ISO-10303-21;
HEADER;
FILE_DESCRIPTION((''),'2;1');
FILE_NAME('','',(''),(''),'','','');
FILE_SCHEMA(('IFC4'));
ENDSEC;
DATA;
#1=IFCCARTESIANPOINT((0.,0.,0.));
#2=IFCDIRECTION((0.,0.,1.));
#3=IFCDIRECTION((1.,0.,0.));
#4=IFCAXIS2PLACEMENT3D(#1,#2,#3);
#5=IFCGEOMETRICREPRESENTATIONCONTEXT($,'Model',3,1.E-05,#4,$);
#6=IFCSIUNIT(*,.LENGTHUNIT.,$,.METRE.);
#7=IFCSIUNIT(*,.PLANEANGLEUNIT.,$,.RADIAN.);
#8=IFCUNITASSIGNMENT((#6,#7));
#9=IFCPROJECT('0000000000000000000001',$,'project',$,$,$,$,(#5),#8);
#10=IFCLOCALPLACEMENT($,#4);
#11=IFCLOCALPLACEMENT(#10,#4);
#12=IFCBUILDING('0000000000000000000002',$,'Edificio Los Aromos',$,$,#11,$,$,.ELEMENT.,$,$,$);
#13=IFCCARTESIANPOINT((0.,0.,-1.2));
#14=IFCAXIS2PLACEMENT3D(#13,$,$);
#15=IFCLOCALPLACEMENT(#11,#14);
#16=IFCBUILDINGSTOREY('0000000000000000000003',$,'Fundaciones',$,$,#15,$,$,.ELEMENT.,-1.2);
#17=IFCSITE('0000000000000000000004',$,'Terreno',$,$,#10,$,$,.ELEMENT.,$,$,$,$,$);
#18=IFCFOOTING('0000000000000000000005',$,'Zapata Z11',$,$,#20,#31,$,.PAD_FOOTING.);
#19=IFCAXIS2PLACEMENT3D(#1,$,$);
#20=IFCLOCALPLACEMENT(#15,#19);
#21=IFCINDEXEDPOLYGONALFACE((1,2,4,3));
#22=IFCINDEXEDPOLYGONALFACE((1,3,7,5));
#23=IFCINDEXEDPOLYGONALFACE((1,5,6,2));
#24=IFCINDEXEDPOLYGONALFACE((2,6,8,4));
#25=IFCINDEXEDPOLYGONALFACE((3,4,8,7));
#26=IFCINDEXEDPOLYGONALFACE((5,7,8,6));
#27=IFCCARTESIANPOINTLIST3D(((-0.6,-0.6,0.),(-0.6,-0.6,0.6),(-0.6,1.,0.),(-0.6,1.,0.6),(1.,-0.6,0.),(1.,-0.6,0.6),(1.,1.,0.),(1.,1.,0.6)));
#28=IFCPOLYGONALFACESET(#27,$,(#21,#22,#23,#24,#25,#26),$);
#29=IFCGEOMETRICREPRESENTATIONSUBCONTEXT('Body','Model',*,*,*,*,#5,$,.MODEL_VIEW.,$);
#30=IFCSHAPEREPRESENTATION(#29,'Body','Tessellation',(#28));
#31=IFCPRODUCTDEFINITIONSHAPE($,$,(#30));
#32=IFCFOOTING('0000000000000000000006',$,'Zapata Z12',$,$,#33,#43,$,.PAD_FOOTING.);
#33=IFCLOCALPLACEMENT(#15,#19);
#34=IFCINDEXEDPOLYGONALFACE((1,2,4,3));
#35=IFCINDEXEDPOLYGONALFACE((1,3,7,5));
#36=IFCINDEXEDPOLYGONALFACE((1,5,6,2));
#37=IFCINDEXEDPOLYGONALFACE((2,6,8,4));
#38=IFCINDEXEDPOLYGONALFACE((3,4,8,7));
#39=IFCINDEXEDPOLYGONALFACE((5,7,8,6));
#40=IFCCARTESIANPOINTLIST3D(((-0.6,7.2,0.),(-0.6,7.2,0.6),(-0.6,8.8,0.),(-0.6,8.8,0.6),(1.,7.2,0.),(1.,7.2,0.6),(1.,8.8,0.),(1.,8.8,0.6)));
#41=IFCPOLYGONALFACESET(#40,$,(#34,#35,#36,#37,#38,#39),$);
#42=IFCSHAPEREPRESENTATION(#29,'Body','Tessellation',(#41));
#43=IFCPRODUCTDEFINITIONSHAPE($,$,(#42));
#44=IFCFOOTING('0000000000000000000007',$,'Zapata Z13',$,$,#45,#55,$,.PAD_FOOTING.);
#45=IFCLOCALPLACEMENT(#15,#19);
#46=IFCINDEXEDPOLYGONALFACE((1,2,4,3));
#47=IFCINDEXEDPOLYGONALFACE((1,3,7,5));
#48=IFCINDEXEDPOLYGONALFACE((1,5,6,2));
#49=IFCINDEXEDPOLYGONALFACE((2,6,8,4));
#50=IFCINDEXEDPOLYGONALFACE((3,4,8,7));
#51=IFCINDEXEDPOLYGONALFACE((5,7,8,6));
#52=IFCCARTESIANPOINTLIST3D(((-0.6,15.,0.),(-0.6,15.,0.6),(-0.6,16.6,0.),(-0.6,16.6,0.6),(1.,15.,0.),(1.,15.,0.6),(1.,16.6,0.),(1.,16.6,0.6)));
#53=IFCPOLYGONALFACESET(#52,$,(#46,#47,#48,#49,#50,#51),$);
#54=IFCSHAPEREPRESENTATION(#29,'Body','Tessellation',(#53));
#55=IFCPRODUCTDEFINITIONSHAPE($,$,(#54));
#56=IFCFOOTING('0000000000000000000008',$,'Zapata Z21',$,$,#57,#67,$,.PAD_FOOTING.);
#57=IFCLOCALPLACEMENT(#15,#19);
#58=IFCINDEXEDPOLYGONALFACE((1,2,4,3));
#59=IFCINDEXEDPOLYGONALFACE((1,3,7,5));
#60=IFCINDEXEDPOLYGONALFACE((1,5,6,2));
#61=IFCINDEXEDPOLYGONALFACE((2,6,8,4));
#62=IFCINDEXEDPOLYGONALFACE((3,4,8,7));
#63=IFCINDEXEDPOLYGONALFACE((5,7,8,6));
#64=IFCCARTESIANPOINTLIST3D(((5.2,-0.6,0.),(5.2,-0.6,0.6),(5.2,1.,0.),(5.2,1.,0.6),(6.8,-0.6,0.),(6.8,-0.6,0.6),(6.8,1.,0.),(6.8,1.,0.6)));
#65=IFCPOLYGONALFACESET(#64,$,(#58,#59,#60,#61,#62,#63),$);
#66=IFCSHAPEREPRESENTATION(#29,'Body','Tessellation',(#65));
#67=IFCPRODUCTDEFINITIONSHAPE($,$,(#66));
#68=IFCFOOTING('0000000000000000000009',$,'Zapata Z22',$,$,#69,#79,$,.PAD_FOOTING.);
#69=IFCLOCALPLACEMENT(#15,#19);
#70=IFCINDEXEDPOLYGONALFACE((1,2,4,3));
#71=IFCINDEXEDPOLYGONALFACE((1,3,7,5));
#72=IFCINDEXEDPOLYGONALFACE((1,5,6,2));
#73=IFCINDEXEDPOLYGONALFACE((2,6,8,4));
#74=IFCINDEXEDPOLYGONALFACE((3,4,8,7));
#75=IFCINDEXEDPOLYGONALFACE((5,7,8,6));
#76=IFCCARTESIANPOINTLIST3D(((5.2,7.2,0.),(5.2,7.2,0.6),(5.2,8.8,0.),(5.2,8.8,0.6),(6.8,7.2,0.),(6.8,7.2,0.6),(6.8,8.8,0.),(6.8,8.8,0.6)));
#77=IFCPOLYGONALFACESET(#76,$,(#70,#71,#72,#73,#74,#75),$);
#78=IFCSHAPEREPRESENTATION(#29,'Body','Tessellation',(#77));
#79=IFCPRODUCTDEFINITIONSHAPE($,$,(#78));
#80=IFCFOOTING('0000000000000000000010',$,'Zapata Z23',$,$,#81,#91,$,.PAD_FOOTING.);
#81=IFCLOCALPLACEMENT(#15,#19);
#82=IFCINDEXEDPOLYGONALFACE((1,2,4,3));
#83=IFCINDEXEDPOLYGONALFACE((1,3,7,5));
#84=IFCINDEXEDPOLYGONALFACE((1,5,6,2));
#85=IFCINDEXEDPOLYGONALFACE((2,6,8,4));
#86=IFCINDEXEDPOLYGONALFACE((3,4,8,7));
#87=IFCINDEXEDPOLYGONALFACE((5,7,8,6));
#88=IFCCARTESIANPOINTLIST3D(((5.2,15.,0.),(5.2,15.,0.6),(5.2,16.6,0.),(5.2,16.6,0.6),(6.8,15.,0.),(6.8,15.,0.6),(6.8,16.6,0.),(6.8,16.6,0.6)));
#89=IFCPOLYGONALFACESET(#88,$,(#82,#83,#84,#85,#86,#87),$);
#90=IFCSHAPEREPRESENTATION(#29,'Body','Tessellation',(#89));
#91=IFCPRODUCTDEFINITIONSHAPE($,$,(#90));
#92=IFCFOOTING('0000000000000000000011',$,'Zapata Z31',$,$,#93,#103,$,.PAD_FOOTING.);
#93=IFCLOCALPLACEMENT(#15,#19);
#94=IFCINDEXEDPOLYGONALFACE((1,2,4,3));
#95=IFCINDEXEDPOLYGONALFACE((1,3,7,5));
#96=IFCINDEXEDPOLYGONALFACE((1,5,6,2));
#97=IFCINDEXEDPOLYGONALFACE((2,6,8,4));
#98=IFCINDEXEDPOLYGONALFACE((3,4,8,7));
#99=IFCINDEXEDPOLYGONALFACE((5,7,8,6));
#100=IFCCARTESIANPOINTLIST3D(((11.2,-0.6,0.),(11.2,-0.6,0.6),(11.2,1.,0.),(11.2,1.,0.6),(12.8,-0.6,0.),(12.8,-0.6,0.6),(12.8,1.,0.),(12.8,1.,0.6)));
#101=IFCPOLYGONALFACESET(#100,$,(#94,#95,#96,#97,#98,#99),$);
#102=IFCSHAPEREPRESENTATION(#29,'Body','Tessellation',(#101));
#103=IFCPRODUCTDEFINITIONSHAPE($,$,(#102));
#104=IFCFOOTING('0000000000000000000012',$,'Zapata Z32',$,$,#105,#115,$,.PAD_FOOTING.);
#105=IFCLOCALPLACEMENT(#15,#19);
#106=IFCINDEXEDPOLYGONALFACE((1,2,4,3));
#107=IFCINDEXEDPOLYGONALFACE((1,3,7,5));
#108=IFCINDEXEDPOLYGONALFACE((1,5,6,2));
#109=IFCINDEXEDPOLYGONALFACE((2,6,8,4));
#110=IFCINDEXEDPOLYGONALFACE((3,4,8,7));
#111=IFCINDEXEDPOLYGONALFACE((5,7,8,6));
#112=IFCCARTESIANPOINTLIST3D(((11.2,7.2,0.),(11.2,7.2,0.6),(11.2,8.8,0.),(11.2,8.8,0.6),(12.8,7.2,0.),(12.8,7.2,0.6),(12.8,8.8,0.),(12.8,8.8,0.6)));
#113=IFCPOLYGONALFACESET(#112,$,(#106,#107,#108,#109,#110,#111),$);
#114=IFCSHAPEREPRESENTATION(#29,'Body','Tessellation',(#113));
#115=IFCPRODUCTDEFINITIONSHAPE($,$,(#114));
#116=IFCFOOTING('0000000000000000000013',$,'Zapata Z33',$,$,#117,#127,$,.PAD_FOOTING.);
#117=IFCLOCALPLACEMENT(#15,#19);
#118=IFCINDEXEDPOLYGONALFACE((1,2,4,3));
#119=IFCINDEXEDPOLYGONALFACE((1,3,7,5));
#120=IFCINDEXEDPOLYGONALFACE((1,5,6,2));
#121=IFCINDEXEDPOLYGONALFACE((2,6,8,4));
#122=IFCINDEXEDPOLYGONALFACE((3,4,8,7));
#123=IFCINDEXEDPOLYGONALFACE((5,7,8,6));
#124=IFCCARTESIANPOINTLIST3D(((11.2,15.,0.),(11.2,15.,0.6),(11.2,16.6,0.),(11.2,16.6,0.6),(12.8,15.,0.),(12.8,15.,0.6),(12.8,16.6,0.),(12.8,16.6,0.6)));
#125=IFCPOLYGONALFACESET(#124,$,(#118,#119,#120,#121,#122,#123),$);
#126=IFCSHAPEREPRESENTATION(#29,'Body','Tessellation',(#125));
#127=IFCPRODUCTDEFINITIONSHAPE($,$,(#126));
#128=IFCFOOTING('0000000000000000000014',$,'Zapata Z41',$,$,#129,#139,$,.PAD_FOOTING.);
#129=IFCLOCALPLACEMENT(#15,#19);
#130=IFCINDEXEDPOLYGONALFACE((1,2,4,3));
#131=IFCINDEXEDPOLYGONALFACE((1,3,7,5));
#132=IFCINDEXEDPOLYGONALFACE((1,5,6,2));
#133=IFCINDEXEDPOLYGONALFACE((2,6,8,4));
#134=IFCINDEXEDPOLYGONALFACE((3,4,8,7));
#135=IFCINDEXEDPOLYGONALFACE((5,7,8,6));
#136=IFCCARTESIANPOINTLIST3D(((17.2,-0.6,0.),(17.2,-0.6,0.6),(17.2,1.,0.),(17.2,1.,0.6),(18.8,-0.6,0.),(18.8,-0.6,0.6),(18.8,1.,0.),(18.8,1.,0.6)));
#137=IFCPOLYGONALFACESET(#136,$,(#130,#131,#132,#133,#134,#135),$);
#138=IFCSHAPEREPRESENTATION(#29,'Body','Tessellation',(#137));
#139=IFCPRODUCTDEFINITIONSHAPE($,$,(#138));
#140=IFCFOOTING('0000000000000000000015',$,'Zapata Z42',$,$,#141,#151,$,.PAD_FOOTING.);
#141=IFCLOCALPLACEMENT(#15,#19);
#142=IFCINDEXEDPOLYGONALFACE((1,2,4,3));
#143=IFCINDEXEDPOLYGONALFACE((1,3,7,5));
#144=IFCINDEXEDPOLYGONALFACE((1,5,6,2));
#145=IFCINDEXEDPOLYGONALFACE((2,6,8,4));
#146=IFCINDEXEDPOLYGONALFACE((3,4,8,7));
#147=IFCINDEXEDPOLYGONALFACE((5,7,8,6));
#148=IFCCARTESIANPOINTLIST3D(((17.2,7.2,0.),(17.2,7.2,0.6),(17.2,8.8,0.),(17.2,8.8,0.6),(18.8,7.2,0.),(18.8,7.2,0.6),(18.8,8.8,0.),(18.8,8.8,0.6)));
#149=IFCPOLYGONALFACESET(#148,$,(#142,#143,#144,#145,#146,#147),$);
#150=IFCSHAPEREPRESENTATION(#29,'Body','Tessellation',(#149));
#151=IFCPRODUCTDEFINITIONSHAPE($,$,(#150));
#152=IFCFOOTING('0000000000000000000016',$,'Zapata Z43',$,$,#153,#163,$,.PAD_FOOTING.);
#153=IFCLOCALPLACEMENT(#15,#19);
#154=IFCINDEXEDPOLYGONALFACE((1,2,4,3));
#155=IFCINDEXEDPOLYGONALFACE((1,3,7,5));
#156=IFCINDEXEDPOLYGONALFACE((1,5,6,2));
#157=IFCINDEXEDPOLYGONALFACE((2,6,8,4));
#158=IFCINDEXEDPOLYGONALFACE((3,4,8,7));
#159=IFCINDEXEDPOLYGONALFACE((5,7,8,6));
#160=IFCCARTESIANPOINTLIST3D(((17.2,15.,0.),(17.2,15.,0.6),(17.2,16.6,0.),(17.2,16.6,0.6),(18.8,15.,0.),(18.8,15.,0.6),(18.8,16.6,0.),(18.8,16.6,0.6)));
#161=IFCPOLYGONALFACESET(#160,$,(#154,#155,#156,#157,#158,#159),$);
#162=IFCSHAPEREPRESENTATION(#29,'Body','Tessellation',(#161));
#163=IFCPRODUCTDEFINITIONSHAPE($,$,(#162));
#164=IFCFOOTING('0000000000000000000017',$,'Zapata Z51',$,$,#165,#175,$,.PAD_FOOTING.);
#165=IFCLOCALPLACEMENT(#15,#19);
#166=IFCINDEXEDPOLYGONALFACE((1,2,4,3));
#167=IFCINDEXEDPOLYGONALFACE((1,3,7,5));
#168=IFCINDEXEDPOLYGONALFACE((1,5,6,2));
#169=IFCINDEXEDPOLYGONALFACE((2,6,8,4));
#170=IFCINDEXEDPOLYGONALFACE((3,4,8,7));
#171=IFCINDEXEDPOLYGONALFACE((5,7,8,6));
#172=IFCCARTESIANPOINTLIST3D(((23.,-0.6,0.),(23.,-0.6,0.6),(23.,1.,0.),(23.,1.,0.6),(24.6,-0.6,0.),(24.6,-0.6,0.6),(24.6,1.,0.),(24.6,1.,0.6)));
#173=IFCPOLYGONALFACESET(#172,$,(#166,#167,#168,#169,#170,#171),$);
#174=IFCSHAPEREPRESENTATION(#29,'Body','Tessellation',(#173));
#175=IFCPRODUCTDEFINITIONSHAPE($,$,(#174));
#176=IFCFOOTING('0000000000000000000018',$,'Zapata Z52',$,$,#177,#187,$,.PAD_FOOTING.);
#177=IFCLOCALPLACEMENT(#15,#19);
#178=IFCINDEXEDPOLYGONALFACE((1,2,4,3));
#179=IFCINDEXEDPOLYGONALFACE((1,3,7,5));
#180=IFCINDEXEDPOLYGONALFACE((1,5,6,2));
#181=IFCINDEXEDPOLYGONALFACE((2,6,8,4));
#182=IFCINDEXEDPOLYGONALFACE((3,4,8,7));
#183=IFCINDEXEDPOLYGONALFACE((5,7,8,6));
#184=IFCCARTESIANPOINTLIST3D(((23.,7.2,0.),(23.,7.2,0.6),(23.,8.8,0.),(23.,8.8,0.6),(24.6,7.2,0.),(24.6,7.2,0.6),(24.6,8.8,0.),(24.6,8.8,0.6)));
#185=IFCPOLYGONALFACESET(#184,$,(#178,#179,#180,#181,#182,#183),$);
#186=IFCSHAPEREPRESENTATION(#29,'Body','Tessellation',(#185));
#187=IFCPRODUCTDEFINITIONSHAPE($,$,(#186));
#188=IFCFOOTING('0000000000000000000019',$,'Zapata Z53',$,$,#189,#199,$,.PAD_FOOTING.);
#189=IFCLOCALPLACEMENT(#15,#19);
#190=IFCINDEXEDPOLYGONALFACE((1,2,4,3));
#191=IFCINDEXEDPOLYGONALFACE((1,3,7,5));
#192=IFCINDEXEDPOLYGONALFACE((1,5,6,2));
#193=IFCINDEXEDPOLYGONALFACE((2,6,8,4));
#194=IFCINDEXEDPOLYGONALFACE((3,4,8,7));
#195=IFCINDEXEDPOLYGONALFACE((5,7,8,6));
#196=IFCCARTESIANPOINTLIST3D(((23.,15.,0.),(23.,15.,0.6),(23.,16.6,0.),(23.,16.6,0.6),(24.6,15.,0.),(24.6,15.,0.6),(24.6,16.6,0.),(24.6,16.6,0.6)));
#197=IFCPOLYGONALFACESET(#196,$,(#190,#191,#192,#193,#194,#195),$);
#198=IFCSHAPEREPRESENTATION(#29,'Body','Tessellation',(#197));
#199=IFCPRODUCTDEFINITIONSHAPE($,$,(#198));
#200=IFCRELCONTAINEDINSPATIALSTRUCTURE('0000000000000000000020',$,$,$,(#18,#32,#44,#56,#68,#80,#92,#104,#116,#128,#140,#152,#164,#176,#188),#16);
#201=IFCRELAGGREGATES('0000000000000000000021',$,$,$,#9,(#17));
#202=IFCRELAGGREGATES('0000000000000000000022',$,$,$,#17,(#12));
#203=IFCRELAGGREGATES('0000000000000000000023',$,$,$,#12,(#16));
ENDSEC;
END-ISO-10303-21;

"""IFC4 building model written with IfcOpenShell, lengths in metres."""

from ifc_helpers import new_model, si_unit, frame, frame_2d, origin_with_axes, place, context, subcontext, project, spatial, rectangle, extrude, element, save


model = new_model("IFC4")

# Units and contexts
model_context = context("Model", 3, precision=1e-05, world=origin_with_axes())
body_context = subcontext(model_context, "Body", "Model", "MODEL_VIEW")
ifc_project = project(units=[si_unit("LENGTHUNIT", "METRE"), si_unit("PLANEANGLEUNIT", "RADIAN")], contexts=[model_context])

# Site, building, storey
site_placement = place(None, origin_with_axes())
site = spatial("IfcSite", under=ifc_project, at=site_placement, Name="Terreno", CompositionType="ELEMENT")
building_placement = place(site_placement, origin_with_axes())
building = spatial("IfcBuilding", under=site, at=building_placement, Name="Edificio Los Aromos", CompositionType="ELEMENT")
storey_placement = place(building_placement, frame((0.0, 0.0, -1.2)))
storey = spatial("IfcBuildingStorey", under=building, at=storey_placement, Name="Fundaciones", CompositionType="ELEMENT", Elevation=-1.2)

# Footings
for number, where, name in (
    (1, (-0.6, -0.6, 0.0), "Zapata Z11"),
    (2, (-0.6, 7.2, 0.0), "Zapata Z12"),
    (3, (-0.6, 15.0, 0.0), "Zapata Z13"),
    (4, (5.2, -0.6, 0.0), "Zapata Z21"),
    (5, (5.2, 7.2, 0.0), "Zapata Z22"),
    (6, (5.2, 15.0, 0.0), "Zapata Z23"),
    (7, (11.2, -0.6, 0.0), "Zapata Z31"),
    (8, (11.2, 7.2, 0.0), "Zapata Z32"),
    (9, (11.2, 15.0, 0.0), "Zapata Z33"),
    (10, (17.2, -0.6, 0.0), "Zapata Z41"),
    (11, (17.2, 7.2, 0.0), "Zapata Z42"),
    (12, (17.2, 15.0, 0.0), "Zapata Z43"),
    (13, (23.0, -0.6, 0.0), "Zapata Z51"),
    (14, (23.0, 7.2, 0.0), "Zapata Z52"),
    (15, (23.0, 15.0, 0.0), "Zapata Z53"),
):
    element("IfcFooting", number, at=place(storey_placement, frame(where)), inside=storey, Name=name, PredefinedType="PAD_FOOTING", context=body_context, shape_type="SweptSolid", body=[
        extrude(rectangle(XDim=1.6, YDim=1.6, at=frame_2d((0.8, 0.8))), origin_with_axes(), (0.0, 0.0, 1.0), 0.6),
    ])

save(model, "model.ifc")
